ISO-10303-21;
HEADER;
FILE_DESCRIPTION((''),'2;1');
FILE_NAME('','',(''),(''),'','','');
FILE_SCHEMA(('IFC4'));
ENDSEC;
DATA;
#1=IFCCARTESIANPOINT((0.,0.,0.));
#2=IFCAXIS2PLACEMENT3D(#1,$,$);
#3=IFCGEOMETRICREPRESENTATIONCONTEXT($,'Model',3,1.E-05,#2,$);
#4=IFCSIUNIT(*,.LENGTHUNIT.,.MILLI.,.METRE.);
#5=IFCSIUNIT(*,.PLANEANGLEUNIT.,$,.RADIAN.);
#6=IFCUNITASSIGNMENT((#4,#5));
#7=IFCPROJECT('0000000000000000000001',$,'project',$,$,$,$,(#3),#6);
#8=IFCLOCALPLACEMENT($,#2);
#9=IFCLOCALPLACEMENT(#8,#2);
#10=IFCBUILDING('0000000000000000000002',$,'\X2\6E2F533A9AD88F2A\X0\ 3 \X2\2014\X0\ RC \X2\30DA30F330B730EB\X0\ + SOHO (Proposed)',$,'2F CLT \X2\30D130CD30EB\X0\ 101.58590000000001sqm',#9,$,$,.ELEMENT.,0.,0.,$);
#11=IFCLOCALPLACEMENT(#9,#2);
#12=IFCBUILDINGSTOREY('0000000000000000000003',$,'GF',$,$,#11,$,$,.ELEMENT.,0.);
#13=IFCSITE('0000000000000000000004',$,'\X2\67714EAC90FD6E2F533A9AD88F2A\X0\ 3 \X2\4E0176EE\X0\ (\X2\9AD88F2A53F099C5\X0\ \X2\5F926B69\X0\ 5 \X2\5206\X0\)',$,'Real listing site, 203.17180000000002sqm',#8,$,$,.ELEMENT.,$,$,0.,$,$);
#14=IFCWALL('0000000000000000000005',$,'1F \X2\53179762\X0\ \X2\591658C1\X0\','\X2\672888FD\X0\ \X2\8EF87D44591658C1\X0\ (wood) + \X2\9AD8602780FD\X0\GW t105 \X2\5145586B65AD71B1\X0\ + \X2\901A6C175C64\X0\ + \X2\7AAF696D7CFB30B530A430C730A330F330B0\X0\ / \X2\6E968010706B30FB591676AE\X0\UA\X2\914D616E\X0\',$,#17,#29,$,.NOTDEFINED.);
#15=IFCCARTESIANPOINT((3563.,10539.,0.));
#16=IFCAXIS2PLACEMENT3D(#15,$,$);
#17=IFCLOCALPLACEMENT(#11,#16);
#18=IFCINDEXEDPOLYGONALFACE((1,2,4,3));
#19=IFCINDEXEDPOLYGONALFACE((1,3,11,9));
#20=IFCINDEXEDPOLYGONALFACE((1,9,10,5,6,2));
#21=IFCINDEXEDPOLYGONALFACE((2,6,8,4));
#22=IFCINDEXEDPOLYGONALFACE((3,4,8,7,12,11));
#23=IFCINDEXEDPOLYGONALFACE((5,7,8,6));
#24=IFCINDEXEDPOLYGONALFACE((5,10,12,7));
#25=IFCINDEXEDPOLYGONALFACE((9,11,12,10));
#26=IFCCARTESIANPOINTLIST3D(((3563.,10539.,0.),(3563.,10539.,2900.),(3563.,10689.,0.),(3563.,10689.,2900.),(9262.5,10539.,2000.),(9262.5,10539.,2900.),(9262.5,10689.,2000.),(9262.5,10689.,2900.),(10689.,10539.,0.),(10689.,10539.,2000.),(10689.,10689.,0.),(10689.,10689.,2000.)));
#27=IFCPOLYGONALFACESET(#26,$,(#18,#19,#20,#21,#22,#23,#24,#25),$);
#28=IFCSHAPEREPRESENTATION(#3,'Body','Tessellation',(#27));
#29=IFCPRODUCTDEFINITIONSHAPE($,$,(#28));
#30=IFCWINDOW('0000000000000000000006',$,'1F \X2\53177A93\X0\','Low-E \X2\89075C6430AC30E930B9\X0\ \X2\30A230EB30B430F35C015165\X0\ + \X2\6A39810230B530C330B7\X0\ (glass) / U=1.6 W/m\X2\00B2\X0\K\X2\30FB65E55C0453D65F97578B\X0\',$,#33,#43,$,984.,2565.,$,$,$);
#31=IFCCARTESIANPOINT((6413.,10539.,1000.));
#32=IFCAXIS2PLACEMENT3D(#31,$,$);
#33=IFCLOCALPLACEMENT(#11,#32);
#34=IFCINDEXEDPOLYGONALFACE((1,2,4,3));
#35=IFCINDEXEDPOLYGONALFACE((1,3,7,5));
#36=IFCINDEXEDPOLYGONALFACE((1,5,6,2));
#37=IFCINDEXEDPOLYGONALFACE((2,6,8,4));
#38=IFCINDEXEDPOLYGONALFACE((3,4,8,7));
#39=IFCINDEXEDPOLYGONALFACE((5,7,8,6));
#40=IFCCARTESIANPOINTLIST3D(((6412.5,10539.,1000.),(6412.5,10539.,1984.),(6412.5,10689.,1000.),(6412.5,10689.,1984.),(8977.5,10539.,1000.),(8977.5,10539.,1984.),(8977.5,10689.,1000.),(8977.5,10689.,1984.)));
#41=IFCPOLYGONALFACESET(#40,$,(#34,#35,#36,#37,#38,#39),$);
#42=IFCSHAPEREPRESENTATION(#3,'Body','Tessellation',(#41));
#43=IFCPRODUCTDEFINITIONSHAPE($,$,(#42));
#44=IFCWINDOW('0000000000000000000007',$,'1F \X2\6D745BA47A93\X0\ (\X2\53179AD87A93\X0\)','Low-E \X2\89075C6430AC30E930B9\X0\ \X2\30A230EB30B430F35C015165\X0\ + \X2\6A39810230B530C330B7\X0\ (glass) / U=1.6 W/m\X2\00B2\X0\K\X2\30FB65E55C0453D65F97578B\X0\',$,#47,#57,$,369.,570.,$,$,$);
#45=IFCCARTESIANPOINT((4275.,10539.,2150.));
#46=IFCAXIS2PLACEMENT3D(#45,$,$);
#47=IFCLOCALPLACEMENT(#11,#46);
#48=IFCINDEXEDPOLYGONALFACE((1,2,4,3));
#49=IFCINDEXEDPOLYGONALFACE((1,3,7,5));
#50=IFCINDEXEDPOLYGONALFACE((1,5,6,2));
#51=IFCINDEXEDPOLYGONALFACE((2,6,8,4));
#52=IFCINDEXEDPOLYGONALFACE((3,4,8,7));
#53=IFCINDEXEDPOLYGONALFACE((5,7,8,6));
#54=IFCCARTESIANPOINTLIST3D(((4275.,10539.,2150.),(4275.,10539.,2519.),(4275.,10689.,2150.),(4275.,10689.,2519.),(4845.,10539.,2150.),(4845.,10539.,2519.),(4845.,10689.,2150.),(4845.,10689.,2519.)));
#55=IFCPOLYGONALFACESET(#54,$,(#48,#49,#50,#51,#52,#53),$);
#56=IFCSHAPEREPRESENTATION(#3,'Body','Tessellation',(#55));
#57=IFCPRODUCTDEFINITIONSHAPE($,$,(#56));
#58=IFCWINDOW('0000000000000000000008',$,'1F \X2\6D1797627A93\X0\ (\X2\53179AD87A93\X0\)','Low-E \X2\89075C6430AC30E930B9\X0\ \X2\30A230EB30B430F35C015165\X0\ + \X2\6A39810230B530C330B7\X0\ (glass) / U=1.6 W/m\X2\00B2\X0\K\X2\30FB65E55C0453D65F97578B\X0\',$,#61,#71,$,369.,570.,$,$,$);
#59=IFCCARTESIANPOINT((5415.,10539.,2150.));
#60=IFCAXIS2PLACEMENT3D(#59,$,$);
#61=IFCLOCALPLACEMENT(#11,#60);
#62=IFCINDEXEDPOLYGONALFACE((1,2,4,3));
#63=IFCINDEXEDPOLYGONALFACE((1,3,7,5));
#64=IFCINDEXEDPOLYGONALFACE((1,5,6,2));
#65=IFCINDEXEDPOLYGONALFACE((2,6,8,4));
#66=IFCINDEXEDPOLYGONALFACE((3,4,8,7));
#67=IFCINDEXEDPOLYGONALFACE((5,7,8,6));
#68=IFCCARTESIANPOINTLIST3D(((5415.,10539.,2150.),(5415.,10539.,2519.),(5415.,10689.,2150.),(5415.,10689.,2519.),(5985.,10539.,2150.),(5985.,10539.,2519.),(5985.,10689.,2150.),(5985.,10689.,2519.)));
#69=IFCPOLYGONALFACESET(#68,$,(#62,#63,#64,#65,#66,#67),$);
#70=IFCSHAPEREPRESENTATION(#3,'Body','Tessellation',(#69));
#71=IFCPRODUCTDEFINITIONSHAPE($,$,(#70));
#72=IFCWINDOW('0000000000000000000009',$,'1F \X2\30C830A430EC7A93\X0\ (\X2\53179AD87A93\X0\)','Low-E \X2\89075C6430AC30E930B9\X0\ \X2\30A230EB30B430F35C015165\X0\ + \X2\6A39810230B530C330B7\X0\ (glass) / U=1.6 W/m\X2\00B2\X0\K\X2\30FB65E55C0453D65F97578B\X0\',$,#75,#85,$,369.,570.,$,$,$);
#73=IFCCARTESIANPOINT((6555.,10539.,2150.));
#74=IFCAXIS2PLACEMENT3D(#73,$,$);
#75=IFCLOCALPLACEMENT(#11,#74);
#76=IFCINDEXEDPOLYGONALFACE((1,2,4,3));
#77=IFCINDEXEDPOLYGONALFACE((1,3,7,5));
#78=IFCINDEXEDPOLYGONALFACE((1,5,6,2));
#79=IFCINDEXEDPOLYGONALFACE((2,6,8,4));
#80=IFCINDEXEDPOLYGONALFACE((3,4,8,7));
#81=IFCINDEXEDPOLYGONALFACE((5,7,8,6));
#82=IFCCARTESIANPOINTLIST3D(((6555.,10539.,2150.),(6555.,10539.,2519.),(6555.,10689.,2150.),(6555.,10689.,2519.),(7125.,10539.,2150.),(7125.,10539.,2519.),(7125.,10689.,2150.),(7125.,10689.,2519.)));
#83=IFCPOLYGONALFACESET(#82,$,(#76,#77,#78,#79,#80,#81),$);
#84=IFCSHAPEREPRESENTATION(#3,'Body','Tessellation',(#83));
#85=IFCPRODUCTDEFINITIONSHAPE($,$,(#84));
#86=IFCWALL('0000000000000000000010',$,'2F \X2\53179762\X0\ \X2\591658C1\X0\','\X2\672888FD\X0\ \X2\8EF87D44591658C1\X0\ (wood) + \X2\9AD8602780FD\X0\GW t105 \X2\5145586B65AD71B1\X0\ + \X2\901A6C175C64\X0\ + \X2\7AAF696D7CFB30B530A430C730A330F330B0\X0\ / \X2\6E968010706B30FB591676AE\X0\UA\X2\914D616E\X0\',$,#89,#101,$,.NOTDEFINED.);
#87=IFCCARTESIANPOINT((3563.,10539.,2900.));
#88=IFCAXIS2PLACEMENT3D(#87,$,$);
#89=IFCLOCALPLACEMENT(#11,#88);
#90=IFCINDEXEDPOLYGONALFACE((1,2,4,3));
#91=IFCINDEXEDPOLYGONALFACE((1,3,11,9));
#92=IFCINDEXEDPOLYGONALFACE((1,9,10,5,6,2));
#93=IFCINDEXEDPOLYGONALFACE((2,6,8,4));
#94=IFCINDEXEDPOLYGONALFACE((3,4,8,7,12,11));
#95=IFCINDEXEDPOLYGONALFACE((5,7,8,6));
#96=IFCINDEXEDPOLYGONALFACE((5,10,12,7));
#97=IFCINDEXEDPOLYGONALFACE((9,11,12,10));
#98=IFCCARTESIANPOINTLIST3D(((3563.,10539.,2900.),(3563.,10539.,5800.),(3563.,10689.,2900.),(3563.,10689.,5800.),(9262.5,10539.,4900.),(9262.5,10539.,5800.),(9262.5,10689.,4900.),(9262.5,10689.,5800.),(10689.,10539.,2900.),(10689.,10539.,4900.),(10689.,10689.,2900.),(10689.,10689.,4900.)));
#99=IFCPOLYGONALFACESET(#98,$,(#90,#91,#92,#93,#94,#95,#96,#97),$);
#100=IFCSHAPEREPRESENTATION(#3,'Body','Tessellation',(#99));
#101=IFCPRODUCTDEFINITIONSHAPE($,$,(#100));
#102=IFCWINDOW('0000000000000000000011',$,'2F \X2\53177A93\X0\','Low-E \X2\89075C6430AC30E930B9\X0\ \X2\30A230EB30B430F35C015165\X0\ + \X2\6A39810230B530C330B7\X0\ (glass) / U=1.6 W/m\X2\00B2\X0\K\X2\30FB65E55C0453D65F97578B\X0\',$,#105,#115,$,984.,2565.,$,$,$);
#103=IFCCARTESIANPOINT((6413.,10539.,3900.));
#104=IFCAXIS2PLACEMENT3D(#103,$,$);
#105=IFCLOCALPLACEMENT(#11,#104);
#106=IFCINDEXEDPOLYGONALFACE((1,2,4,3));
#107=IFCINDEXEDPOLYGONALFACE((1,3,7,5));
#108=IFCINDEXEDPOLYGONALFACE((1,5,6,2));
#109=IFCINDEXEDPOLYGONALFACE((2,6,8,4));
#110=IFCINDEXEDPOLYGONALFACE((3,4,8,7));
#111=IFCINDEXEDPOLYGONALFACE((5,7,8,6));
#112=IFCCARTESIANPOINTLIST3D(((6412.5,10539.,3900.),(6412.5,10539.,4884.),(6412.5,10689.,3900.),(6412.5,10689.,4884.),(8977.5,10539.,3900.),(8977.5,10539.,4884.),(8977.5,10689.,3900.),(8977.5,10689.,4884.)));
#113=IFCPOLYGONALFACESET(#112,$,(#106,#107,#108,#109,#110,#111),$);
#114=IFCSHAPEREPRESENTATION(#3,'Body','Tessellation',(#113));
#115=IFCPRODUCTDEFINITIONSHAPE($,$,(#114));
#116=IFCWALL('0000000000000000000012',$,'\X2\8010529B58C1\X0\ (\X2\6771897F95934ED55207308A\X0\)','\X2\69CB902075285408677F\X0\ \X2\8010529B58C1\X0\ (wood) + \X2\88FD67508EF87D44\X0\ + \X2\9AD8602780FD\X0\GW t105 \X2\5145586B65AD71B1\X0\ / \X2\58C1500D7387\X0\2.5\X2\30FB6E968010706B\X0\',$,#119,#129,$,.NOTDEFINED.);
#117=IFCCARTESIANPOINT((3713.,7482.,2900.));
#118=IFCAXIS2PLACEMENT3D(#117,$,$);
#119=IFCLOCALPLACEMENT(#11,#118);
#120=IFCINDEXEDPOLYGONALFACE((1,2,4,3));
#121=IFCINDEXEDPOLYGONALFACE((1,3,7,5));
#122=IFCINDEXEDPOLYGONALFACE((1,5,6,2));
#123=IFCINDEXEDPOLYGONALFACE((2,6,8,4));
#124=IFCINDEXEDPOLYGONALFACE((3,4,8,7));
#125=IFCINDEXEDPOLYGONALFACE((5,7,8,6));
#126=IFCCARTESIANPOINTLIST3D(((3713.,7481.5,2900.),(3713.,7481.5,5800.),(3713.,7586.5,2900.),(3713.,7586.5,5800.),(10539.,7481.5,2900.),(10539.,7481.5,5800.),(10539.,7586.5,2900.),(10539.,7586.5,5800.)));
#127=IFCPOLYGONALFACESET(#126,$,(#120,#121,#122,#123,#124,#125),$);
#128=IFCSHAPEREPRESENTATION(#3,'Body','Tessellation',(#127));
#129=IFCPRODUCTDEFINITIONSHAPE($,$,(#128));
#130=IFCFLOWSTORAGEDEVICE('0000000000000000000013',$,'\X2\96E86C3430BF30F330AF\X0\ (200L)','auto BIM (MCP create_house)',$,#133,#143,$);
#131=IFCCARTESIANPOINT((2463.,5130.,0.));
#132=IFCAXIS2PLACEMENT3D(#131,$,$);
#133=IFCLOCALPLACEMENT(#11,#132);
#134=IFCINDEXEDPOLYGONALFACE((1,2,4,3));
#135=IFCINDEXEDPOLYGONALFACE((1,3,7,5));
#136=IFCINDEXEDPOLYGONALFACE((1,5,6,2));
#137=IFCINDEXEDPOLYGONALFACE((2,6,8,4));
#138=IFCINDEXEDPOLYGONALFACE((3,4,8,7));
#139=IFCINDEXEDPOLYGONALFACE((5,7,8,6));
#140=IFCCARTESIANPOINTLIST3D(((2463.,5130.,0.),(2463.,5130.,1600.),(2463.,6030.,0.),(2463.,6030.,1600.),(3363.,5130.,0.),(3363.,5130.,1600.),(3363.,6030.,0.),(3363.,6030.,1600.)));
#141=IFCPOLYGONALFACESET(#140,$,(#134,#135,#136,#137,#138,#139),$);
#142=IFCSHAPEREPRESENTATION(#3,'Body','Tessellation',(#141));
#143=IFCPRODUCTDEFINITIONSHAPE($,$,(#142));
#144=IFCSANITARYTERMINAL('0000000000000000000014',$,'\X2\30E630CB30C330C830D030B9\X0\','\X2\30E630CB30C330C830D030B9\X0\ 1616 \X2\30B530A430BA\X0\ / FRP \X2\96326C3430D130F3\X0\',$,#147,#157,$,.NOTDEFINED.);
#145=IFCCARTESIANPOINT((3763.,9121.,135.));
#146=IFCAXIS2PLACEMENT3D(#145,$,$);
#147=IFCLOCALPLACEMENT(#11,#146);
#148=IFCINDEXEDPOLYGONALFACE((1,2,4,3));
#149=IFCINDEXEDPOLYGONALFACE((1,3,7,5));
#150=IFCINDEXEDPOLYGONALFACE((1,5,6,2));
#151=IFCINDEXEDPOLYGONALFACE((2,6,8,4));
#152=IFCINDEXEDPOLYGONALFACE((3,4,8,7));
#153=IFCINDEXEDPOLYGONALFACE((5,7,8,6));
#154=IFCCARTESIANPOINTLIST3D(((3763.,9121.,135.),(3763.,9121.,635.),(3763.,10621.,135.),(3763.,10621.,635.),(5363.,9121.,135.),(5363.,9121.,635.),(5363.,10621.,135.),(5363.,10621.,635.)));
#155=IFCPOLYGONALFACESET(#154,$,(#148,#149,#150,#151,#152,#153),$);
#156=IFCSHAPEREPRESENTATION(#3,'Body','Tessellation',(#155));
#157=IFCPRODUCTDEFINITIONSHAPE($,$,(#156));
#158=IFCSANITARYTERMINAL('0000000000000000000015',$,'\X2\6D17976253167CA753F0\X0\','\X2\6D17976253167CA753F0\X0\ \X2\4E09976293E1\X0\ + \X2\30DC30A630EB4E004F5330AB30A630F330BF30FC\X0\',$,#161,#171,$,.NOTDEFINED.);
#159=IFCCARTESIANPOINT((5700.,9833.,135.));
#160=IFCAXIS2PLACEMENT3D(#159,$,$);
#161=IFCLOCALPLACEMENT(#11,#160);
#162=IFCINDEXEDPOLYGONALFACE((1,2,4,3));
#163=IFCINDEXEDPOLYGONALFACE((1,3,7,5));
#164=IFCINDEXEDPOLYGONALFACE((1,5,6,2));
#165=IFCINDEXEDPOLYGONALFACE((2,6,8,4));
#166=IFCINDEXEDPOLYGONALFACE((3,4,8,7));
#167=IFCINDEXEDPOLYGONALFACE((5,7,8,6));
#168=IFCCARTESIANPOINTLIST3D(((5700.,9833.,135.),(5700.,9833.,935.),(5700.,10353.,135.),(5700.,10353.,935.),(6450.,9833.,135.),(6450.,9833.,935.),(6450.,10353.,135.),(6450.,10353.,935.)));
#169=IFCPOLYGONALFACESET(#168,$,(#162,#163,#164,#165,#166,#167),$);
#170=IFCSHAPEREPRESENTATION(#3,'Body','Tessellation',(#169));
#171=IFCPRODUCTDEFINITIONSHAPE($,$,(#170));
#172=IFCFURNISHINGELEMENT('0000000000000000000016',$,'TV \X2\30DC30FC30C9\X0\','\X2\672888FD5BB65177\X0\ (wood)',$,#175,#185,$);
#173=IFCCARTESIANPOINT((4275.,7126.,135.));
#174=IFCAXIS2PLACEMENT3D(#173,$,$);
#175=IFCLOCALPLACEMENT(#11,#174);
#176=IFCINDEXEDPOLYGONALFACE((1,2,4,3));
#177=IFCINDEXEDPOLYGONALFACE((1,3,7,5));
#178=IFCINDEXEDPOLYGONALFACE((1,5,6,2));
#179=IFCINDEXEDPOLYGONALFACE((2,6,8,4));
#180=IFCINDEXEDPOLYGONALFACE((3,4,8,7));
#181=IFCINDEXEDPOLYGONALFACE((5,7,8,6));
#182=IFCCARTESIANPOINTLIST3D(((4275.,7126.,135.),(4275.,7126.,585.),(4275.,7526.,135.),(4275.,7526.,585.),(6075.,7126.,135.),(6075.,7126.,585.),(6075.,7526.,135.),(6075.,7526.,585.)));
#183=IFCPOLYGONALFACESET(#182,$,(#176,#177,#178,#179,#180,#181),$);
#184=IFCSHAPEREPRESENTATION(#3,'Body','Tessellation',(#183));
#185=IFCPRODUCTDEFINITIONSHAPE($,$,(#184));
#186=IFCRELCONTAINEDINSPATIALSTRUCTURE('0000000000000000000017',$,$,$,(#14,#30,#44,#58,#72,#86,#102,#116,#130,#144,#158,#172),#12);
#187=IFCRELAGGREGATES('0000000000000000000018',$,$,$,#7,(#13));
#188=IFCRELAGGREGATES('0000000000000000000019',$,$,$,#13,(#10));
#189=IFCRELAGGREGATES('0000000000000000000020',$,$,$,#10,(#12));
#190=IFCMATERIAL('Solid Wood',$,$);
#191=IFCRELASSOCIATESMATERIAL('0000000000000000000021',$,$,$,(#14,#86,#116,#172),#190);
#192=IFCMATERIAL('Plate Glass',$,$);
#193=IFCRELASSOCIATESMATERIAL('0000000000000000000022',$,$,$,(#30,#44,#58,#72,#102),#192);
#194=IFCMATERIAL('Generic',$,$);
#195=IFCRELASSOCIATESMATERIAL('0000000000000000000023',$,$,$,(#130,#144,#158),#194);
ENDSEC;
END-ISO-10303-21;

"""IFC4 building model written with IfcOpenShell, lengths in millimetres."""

from ifc_helpers import new_model, si_unit, frame, frame_2d, origin, place, context, project, spatial, rectangle, extrude, material, element, fill, save


model = new_model("IFC4")

# Units and contexts
model_context = context("Model", 3, precision=1e-05, world=origin())
ifc_project = project(units=[si_unit("LENGTHUNIT", "METRE", prefix="MILLI"), si_unit("PLANEANGLEUNIT", "RADIAN")], contexts=[model_context])

# Site, building, storey
site_placement = place(None, origin())
site = spatial("IfcSite", under=ifc_project, at=site_placement, Name="東京都港区高輪 3 丁目 (高輪台駅 徒歩 5 分)", ObjectType="Real listing site, 203.17180000000002sqm", CompositionType="ELEMENT", RefElevation=0.0)
building_placement = place(site_placement, origin())
building = spatial("IfcBuilding", under=site, at=building_placement, Name="港区高輪 3 — RC ペンシル + SOHO (Proposed)", ObjectType="2F CLT パネル 101.58590000000001sqm", CompositionType="ELEMENT", ElevationOfRefHeight=0.0, ElevationOfTerrain=0.0)
storey_placement = place(building_placement, origin())
storey = spatial("IfcBuildingStorey", under=building, at=storey_placement, Name="GF", CompositionType="ELEMENT", Elevation=0.0)

# Wall, openings, windows
ifc_material_1 = material(Name="Solid Wood")
wall_1_placement = place(storey_placement, frame((3563.0, 10539.0, 0.0)))
wall_1 = element("IfcWall", 1, at=wall_1_placement, inside=storey, material=ifc_material_1, Name="1F 北面 外壁", Description="木製 軸組外壁 (wood) + 高性能GW t105 充填断熱 + 通気層 + 窯業系サイディング / 準耐火・外皮UA配慮", PredefinedType="NOTDEFINED", context=model_context, shape_type="SweptSolid", body=[
    extrude(rectangle(XDim=7126.0, YDim=150.0, at=frame_2d((3563.0, 75.0))), frame((3563.0, 10539.0, 0.0)), (0.0, 0.0, 1.0), 2900.0),
])
opening_1_placement = place(storey_placement, frame((6413.0, 10539.0, 1000.0)))
opening_1 = element("IfcOpeningElement", 2, at=opening_1_placement, cuts=wall_1, PredefinedType="NOTDEFINED", context=model_context, shape_type="SweptSolid", body=[
    extrude(rectangle(XDim=2565.0, YDim=150.0, at=frame_2d((1282.0, 75.0))), frame((6413.0, 10539.0, 1000.0)), (0.0, 0.0, 1.0), 984.0),
])
opening_2_placement = place(storey_placement, frame((4275.0, 10539.0, 2150.0)))
opening_2 = element("IfcOpeningElement", 3, at=opening_2_placement, cuts=wall_1, PredefinedType="NOTDEFINED", context=model_context, shape_type="SweptSolid", body=[
    extrude(rectangle(XDim=570.0, YDim=150.0, at=frame_2d((285.0, 75.0))), frame((4275.0, 10539.0, 2150.0)), (0.0, 0.0, 1.0), 369.0),
])
opening_3_placement = place(storey_placement, frame((5415.0, 10539.0, 2150.0)))
opening_3 = element("IfcOpeningElement", 4, at=opening_3_placement, cuts=wall_1, PredefinedType="NOTDEFINED", context=model_context, shape_type="SweptSolid", body=[
    extrude(rectangle(XDim=570.0, YDim=150.0, at=frame_2d((285.0, 75.0))), frame((5415.0, 10539.0, 2150.0)), (0.0, 0.0, 1.0), 369.0),
])
opening_4_placement = place(storey_placement, frame((6555.0, 10539.0, 2150.0)))
opening_4 = element("IfcOpeningElement", 5, at=opening_4_placement, cuts=wall_1, PredefinedType="NOTDEFINED", context=model_context, shape_type="SweptSolid", body=[
    extrude(rectangle(XDim=570.0, YDim=150.0, at=frame_2d((285.0, 75.0))), frame((6555.0, 10539.0, 2150.0)), (0.0, 0.0, 1.0), 369.0),
])
ifc_material_2 = material(Name="Plate Glass")
window_1_placement = place(storey_placement, frame((6413.0, 10539.0, 1000.0)))
window_1 = element("IfcWindow", 6, at=window_1_placement, inside=storey, material=ifc_material_2, Name="1F 北窓", Description="Low-E 複層ガラス アルゴン封入 + 樹脂サッシ (glass) / U=1.6 W/m²K・日射取得型", OverallHeight=984.0, OverallWidth=2565.0, context=model_context, shape_type="SweptSolid", body=[
    extrude(rectangle(XDim=2565.0, YDim=150.0, at=frame_2d((1282.0, 75.0))), frame((6413.0, 10539.0, 1000.0)), (0.0, 0.0, 1.0), 984.0),
])
fill(opening_1, window_1)
window_2_placement = place(storey_placement, frame((4275.0, 10539.0, 2150.0)))
window_2 = element("IfcWindow", 7, at=window_2_placement, inside=storey, material=ifc_material_2, Name="1F 浴室窓 (北高窓)", Description="Low-E 複層ガラス アルゴン封入 + 樹脂サッシ (glass) / U=1.6 W/m²K・日射取得型", OverallHeight=369.0, OverallWidth=570.0, context=model_context, shape_type="SweptSolid", body=[
    extrude(rectangle(XDim=570.0, YDim=150.0, at=frame_2d((285.0, 75.0))), frame((4275.0, 10539.0, 2150.0)), (0.0, 0.0, 1.0), 369.0),
])
fill(opening_2, window_2)
window_3_placement = place(storey_placement, frame((5415.0, 10539.0, 2150.0)))
window_3 = element("IfcWindow", 8, at=window_3_placement, inside=storey, material=ifc_material_2, Name="1F 洗面窓 (北高窓)", Description="Low-E 複層ガラス アルゴン封入 + 樹脂サッシ (glass) / U=1.6 W/m²K・日射取得型", OverallHeight=369.0, OverallWidth=570.0, context=model_context, shape_type="SweptSolid", body=[
    extrude(rectangle(XDim=570.0, YDim=150.0, at=frame_2d((285.0, 75.0))), frame((5415.0, 10539.0, 2150.0)), (0.0, 0.0, 1.0), 369.0),
])
fill(opening_3, window_3)
window_4_placement = place(storey_placement, frame((6555.0, 10539.0, 2150.0)))
window_4 = element("IfcWindow", 9, at=window_4_placement, inside=storey, material=ifc_material_2, Name="1F トイレ窓 (北高窓)", Description="Low-E 複層ガラス アルゴン封入 + 樹脂サッシ (glass) / U=1.6 W/m²K・日射取得型", OverallHeight=369.0, OverallWidth=570.0, context=model_context, shape_type="SweptSolid", body=[
    extrude(rectangle(XDim=570.0, YDim=150.0, at=frame_2d((285.0, 75.0))), frame((6555.0, 10539.0, 2150.0)), (0.0, 0.0, 1.0), 369.0),
])
fill(opening_4, window_4)

# Wall, opening, window
wall_2_placement = place(storey_placement, frame((3563.0, 10539.0, 2900.0)))
wall_2 = element("IfcWall", 10, at=wall_2_placement, inside=storey, material=ifc_material_1, Name="2F 北面 外壁", Description="木製 軸組外壁 (wood) + 高性能GW t105 充填断熱 + 通気層 + 窯業系サイディング / 準耐火・外皮UA配慮", PredefinedType="NOTDEFINED", context=model_context, shape_type="SweptSolid", body=[
    extrude(rectangle(XDim=7126.0, YDim=150.0, at=frame_2d((3563.0, 75.0))), frame((3563.0, 10539.0, 2900.0)), (0.0, 0.0, 1.0), 2900.0),
])
opening_5_placement = place(storey_placement, frame((6413.0, 10539.0, 3900.0)))
opening_5 = element("IfcOpeningElement", 11, at=opening_5_placement, cuts=wall_2, PredefinedType="NOTDEFINED", context=model_context, shape_type="SweptSolid", body=[
    extrude(rectangle(XDim=2565.0, YDim=150.0, at=frame_2d((1282.0, 75.0))), frame((6413.0, 10539.0, 3900.0)), (0.0, 0.0, 1.0), 984.0),
])
window_5_placement = place(storey_placement, frame((6413.0, 10539.0, 3900.0)))
window_5 = element("IfcWindow", 12, at=window_5_placement, inside=storey, material=ifc_material_2, Name="2F 北窓", Description="Low-E 複層ガラス アルゴン封入 + 樹脂サッシ (glass) / U=1.6 W/m²K・日射取得型", OverallHeight=984.0, OverallWidth=2565.0, context=model_context, shape_type="SweptSolid", body=[
    extrude(rectangle(XDim=2565.0, YDim=150.0, at=frame_2d((1282.0, 75.0))), frame((6413.0, 10539.0, 3900.0)), (0.0, 0.0, 1.0), 984.0),
])
fill(opening_5, window_5)

# Wall
wall_3_placement = place(storey_placement, frame((3713.0, 7482.0, 2900.0)))
element("IfcWall", 13, at=wall_3_placement, inside=storey, material=ifc_material_1, Name="耐力壁 (東西間仕切り)", Description="構造用合板 耐力壁 (wood) + 製材軸組 + 高性能GW t105 充填断熱 / 壁倍率2.5・準耐火", PredefinedType="NOTDEFINED", context=model_context, shape_type="SweptSolid", body=[
    extrude(rectangle(XDim=6826.0, YDim=105.0, at=frame_2d((3413.0, 52.0))), frame((3713.0, 7482.0, 2900.0)), (0.0, 0.0, 1.0), 2900.0),
])

# Flow storage device
ifc_material_3 = material(Name="Generic")
flow_storage_device_placement = place(storey_placement, frame((2463.0, 5130.0, 0.0)))
element("IfcFlowStorageDevice", 14, at=flow_storage_device_placement, inside=storey, material=ifc_material_3, Name="雨水タンク (200L)", Description="auto BIM (MCP create_house)", context=model_context, shape_type="SweptSolid", body=[
    extrude(rectangle(XDim=900.0, YDim=900.0, at=frame_2d((450.0, 450.0))), frame((2463.0, 5130.0, 0.0)), (0.0, 0.0, 1.0), 1600.0),
])

# Sanitary terminals
sanitary_terminal_1_placement = place(storey_placement, frame((3763.0, 9121.0, 135.0)))
element("IfcSanitaryTerminal", 15, at=sanitary_terminal_1_placement, inside=storey, material=ifc_material_3, Name="ユニットバス", Description="ユニットバス 1616 サイズ / FRP 防水パン", PredefinedType="NOTDEFINED", context=model_context, shape_type="SweptSolid", body=[
    extrude(rectangle(XDim=1600.0, YDim=1500.0, at=frame_2d((800.0, 750.0))), frame((3763.0, 9121.0, 135.0)), (0.0, 0.0, 1.0), 500.0),
])
sanitary_terminal_2_placement = place(storey_placement, frame((5700.0, 9833.0, 135.0)))
element("IfcSanitaryTerminal", 16, at=sanitary_terminal_2_placement, inside=storey, material=ifc_material_3, Name="洗面化粧台", Description="洗面化粧台 三面鏡 + ボウル一体カウンター", PredefinedType="NOTDEFINED", context=model_context, shape_type="SweptSolid", body=[
    extrude(rectangle(XDim=750.0, YDim=520.0, at=frame_2d((375.0, 260.0))), frame((5700.0, 9833.0, 135.0)), (0.0, 0.0, 1.0), 800.0),
])

# Furnishing element
furnishing_1_placement = place(storey_placement, frame((4275.0, 7126.0, 135.0)))
element("IfcFurnishingElement", 17, at=furnishing_1_placement, inside=storey, material=ifc_material_1, Name="TV ボード", Description="木製家具 (wood)", context=model_context, shape_type="SweptSolid", body=[
    extrude(rectangle(XDim=1800.0, YDim=400.0, at=frame_2d((900.0, 200.0))), frame((4275.0, 7126.0, 135.0)), (0.0, 0.0, 1.0), 450.0),
])

save(model, "model.ifc")
